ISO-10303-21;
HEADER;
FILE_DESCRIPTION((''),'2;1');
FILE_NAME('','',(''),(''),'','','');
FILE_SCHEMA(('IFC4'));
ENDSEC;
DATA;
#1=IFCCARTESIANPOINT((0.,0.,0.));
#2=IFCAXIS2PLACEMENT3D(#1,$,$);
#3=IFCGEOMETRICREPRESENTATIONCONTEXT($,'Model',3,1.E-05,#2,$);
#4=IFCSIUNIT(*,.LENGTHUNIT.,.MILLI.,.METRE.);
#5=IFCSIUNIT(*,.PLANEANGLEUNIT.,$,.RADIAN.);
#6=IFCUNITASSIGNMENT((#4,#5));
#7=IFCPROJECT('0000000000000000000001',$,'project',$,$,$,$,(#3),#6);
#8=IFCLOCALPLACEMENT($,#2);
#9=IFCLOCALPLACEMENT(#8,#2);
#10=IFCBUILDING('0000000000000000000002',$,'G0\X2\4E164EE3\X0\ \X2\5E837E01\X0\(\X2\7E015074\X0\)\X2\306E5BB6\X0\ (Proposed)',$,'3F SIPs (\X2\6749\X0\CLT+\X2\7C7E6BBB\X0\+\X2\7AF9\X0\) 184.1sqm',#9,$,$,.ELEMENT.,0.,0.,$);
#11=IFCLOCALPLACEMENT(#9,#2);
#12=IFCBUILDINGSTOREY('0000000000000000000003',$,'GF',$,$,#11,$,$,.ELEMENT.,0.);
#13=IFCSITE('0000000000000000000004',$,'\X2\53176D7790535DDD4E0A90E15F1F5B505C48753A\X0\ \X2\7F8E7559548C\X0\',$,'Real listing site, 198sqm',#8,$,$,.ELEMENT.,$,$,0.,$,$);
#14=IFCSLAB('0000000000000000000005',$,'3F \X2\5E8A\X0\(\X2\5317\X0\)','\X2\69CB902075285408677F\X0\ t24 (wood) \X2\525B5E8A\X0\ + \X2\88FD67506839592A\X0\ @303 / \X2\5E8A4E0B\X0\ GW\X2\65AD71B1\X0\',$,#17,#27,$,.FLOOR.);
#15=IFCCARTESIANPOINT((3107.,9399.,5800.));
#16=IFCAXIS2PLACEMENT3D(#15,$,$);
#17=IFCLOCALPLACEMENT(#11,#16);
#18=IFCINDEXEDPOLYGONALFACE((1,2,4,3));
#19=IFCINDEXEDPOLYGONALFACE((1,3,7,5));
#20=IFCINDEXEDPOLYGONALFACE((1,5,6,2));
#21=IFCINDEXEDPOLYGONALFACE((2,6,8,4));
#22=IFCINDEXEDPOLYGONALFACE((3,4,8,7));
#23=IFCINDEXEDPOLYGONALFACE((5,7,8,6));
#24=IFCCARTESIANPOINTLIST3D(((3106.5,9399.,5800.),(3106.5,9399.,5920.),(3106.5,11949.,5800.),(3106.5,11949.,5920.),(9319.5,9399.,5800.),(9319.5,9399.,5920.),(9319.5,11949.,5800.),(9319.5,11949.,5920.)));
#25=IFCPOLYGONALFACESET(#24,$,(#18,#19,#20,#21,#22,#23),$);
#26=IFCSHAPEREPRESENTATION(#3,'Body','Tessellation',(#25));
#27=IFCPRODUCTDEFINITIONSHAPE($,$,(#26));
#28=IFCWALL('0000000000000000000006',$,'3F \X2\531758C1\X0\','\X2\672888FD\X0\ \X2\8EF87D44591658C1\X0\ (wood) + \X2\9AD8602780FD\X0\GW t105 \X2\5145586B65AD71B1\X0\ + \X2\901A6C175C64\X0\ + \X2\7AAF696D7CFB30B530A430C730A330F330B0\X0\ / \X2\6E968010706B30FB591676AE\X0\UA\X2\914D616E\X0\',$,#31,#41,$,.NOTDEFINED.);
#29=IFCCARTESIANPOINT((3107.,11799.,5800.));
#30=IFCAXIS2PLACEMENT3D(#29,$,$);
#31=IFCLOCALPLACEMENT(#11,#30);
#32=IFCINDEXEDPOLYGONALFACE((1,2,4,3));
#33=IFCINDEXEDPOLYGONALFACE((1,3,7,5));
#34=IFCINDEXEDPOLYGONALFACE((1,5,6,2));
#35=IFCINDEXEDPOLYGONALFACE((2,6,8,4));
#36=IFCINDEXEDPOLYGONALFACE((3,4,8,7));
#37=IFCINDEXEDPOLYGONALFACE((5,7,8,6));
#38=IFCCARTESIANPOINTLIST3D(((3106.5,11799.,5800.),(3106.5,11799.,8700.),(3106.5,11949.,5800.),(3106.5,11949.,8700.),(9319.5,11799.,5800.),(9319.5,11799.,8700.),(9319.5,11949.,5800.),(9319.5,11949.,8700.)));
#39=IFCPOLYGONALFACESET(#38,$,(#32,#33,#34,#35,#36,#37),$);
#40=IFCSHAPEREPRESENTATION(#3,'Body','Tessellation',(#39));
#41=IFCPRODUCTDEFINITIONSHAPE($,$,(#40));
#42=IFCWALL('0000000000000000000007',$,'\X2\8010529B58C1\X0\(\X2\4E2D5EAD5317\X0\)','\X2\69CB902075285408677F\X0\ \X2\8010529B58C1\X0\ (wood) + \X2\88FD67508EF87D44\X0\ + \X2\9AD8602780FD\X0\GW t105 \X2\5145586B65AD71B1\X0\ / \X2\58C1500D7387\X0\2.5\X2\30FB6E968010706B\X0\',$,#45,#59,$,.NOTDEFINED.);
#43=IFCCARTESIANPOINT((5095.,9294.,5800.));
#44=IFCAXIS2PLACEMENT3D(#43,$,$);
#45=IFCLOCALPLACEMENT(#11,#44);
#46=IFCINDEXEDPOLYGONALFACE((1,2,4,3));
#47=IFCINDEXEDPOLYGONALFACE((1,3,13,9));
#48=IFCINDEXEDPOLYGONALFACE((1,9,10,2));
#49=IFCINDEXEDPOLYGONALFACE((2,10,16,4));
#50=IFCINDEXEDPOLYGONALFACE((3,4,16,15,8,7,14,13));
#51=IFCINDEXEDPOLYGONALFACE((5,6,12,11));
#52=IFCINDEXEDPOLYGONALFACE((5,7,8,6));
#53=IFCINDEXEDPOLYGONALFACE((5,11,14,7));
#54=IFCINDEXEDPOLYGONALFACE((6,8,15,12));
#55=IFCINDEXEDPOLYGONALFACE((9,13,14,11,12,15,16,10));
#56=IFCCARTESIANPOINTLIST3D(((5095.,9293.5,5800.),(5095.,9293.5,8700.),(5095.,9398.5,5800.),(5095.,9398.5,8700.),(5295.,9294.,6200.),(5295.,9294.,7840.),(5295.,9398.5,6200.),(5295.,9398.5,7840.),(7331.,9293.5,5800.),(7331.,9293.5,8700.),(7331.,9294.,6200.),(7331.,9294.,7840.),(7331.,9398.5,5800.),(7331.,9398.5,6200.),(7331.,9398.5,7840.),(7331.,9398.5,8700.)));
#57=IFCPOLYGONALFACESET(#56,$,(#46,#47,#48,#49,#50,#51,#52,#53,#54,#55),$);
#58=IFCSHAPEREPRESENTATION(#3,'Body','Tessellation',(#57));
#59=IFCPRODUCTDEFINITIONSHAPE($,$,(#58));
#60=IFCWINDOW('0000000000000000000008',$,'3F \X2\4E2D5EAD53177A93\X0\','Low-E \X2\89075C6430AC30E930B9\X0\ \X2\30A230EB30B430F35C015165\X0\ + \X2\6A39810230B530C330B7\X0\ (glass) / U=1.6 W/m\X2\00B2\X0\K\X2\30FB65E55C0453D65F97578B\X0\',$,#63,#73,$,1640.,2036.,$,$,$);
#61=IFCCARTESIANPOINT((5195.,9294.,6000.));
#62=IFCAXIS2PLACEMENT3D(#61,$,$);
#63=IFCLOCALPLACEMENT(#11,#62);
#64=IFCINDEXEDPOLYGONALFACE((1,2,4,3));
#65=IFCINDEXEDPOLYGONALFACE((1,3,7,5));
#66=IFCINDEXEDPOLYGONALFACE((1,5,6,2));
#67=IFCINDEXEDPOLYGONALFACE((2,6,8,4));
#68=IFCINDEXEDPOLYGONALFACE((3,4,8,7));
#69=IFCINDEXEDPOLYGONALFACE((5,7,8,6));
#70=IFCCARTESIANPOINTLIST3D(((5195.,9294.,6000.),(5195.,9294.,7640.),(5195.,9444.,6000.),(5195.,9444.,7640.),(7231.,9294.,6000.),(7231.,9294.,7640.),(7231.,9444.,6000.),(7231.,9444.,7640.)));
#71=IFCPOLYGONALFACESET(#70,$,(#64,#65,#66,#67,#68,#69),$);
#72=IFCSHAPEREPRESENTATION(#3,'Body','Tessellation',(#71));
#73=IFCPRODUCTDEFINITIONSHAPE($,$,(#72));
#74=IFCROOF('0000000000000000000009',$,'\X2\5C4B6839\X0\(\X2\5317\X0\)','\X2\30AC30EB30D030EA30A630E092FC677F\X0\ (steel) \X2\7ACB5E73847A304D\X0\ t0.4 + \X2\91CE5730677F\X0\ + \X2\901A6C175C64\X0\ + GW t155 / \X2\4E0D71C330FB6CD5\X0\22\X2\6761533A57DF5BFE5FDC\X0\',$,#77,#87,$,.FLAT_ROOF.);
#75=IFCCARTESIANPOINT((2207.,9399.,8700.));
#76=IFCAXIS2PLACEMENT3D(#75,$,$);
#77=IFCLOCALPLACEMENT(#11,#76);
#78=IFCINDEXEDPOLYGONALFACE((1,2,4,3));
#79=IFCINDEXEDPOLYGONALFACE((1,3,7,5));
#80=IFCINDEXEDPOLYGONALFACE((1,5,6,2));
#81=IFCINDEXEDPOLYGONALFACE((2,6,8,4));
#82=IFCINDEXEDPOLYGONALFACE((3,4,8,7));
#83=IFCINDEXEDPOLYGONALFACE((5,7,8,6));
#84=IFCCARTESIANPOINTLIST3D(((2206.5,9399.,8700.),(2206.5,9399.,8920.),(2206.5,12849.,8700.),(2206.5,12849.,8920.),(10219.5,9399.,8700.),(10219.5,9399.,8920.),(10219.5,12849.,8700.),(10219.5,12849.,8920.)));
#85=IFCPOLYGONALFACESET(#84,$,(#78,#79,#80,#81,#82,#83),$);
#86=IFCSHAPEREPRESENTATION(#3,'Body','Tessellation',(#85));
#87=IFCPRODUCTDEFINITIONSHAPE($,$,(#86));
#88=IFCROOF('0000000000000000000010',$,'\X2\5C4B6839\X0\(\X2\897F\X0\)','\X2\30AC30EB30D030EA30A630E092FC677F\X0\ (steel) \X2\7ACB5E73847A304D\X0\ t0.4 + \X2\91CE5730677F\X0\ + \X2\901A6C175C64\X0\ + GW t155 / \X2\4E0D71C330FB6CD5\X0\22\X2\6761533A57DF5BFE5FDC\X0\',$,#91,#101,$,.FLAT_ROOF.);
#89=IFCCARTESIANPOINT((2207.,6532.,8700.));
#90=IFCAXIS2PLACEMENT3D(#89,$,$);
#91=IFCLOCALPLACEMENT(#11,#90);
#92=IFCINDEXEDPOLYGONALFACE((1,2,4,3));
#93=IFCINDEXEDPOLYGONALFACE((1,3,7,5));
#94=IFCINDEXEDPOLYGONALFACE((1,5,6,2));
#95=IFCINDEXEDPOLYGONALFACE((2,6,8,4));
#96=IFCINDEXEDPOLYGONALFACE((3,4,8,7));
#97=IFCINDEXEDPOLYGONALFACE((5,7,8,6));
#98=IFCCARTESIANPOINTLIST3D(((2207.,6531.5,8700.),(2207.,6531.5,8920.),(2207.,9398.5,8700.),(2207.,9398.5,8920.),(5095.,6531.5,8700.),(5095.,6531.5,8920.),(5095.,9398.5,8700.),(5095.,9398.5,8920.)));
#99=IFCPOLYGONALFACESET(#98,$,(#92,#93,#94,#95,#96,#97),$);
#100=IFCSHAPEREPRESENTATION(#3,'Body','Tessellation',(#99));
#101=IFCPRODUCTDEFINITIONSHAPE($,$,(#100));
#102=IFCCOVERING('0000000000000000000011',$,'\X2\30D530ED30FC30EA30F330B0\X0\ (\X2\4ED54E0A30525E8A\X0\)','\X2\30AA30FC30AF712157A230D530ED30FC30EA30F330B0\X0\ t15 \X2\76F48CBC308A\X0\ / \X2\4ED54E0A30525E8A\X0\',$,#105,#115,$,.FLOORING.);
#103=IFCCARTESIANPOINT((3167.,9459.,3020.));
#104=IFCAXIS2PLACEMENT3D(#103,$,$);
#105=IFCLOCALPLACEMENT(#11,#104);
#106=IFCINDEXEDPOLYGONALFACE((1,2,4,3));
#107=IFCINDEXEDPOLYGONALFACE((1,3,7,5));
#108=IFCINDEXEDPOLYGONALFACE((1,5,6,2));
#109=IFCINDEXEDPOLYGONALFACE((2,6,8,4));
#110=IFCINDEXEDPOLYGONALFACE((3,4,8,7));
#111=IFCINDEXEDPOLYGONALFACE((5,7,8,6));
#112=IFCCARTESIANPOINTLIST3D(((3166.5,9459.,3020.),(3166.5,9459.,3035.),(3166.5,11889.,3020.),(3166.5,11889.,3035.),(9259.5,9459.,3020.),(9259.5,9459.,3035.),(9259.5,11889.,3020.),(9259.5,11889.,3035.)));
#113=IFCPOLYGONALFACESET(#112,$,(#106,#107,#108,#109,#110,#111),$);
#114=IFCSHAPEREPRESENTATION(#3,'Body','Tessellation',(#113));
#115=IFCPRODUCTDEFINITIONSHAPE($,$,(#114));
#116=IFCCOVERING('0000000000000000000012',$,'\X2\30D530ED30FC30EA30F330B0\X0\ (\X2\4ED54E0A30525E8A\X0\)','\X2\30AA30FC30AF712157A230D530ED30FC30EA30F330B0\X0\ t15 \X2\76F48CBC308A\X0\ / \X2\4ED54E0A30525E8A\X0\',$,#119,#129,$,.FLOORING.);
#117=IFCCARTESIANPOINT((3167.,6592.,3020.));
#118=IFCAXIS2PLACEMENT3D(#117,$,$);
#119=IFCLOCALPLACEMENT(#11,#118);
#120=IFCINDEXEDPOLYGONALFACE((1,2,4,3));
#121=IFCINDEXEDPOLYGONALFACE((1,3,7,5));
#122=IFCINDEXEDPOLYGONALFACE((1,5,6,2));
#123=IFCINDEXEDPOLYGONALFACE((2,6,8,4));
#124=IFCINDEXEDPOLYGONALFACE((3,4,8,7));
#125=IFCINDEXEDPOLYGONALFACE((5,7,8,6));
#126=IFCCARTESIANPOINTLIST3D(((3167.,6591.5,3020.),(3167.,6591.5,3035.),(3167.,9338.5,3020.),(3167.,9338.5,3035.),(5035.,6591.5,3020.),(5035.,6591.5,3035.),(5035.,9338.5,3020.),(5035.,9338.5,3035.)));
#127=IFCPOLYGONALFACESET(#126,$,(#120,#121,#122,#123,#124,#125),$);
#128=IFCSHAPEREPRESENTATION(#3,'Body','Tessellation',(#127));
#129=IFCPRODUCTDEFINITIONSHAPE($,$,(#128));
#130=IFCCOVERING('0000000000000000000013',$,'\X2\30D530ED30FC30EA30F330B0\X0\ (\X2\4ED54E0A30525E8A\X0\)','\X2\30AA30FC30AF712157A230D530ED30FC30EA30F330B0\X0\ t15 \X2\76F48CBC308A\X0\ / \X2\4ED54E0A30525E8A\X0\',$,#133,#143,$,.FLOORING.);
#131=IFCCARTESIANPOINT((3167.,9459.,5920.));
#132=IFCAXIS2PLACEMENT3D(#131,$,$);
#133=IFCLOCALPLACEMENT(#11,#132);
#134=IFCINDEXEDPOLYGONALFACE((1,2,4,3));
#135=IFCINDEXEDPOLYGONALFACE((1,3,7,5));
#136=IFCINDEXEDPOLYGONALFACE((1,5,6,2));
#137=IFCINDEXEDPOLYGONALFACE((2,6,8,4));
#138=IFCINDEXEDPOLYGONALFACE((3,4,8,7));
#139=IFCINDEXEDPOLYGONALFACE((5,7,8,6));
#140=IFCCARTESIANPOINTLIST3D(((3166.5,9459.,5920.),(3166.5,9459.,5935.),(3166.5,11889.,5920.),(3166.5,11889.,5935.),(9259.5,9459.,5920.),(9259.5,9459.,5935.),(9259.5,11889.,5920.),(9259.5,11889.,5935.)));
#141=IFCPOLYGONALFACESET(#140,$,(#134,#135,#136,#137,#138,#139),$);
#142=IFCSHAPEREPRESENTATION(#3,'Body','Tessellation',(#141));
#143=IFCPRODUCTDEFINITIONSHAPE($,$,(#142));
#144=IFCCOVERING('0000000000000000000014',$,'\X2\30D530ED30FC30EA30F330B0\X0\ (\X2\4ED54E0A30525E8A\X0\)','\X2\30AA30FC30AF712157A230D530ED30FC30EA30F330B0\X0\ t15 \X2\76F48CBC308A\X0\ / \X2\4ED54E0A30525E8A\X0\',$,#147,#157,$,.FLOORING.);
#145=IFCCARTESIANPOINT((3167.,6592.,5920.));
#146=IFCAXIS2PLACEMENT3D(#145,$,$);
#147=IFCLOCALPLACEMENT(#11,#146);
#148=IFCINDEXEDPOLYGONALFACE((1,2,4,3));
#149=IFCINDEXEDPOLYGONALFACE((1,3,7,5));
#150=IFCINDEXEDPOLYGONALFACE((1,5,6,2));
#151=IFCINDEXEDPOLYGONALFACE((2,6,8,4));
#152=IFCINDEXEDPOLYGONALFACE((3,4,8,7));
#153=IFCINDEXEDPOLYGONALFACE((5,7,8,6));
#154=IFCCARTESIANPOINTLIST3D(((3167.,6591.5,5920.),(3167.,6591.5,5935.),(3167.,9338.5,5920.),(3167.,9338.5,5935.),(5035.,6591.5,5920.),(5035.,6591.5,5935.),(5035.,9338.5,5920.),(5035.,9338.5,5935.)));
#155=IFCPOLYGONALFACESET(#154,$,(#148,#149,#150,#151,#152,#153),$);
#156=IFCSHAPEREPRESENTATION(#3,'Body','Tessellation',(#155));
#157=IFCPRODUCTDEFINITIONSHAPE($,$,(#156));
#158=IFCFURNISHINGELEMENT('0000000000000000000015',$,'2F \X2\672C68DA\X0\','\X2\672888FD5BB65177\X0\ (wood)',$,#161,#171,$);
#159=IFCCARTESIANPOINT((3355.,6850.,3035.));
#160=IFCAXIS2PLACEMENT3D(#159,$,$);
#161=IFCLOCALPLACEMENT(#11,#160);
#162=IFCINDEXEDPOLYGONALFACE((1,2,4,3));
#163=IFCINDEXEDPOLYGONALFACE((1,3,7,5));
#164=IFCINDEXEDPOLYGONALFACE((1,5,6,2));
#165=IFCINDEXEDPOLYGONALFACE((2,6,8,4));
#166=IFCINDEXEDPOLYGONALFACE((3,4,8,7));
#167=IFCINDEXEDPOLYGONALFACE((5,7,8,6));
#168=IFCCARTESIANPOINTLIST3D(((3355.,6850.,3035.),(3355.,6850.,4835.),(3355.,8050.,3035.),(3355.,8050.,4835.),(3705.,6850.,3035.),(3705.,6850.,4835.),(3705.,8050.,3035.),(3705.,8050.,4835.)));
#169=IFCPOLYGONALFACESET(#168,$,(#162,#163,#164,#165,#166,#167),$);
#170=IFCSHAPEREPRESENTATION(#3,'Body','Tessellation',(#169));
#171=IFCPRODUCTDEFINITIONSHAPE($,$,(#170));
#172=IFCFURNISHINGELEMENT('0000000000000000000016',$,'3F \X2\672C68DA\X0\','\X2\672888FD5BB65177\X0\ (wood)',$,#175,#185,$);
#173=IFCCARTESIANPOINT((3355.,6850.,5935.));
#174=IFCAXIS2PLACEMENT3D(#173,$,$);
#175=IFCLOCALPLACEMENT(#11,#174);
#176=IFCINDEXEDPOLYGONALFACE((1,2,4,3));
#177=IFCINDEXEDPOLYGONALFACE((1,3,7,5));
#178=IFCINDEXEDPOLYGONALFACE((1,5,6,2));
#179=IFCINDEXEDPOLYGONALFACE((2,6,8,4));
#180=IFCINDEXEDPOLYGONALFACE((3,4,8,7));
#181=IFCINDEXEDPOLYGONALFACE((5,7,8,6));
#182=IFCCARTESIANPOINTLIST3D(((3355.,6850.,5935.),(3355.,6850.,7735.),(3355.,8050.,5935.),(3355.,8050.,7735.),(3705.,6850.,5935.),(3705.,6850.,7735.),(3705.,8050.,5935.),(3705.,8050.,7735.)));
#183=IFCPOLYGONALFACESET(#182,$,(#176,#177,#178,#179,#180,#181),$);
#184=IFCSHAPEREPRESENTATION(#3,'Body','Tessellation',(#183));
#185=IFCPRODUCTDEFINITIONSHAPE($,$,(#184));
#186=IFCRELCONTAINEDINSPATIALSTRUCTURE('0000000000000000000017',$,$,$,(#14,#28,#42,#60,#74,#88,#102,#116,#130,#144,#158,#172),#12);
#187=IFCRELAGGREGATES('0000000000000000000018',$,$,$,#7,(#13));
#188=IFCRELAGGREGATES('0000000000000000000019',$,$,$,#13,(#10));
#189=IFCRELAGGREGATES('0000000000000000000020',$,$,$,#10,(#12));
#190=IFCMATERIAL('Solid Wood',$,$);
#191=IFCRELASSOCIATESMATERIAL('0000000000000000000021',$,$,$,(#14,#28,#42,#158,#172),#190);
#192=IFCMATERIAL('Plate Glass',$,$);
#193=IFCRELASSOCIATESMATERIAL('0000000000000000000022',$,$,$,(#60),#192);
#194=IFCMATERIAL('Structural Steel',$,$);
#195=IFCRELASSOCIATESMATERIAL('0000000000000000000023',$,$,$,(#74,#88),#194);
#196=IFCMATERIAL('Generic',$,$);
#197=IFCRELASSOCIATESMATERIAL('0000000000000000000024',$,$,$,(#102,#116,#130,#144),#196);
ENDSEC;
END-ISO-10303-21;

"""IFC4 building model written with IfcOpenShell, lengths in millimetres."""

from ifc_helpers import new_model, si_unit, frame, frame_2d, origin, place, context, project, spatial, rectangle, extrude, material, element, fill, save


model = new_model("IFC4")

# Units and contexts
model_context = context("Model", 3, precision=1e-05, world=origin())
ifc_project = project(units=[si_unit("LENGTHUNIT", "METRE", prefix="MILLI"), si_unit("PLANEANGLEUNIT", "RADIAN")], contexts=[model_context])

# Site, building, storey
site_placement = place(None, origin())
site = spatial("IfcSite", under=ifc_project, at=site_placement, Name="北海道川上郡弟子屈町 美留和", ObjectType="Real listing site, 198sqm", CompositionType="ELEMENT", RefElevation=0.0)
building_placement = place(site_placement, origin())
building = spatial("IfcBuilding", under=site, at=building_placement, Name="G0世代 広縁(縁側)の家 (Proposed)", ObjectType="3F SIPs (杉CLT+籾殻+竹) 184.1sqm", CompositionType="ELEMENT", ElevationOfRefHeight=0.0, ElevationOfTerrain=0.0)
storey_placement = place(building_placement, origin())
storey = spatial("IfcBuildingStorey", under=building, at=storey_placement, Name="GF", CompositionType="ELEMENT", Elevation=0.0)

# Slab
ifc_material_1 = material(Name="Solid Wood")
slab_placement = place(storey_placement, frame((3107.0, 9399.0, 5800.0)))
element("IfcSlab", 1, at=slab_placement, inside=storey, material=ifc_material_1, Name="3F 床(北)", Description="構造用合板 t24 (wood) 剛床 + 製材根太 @303 / 床下 GW断熱", PredefinedType="FLOOR", context=model_context, shape_type="SweptSolid", body=[
    extrude(rectangle(XDim=6213.0, YDim=2550.0, at=frame_2d((3106.0, 1275.0))), frame((3107.0, 9399.0, 5800.0)), (0.0, 0.0, 1.0), 120.0),
])

# Wall
wall_1_placement = place(storey_placement, frame((3107.0, 11799.0, 5800.0)))
element("IfcWall", 2, at=wall_1_placement, inside=storey, material=ifc_material_1, Name="3F 北壁", Description="木製 軸組外壁 (wood) + 高性能GW t105 充填断熱 + 通気層 + 窯業系サイディング / 準耐火・外皮UA配慮", PredefinedType="NOTDEFINED", context=model_context, shape_type="SweptSolid", body=[
    extrude(rectangle(XDim=6213.0, YDim=150.0, at=frame_2d((3106.0, 75.0))), frame((3107.0, 11799.0, 5800.0)), (0.0, 0.0, 1.0), 2900.0),
])

# Wall, opening, window
wall_2_placement = place(storey_placement, frame((5095.0, 9294.0, 5800.0)))
wall_2 = element("IfcWall", 3, at=wall_2_placement, inside=storey, material=ifc_material_1, Name="耐力壁(中庭北)", Description="構造用合板 耐力壁 (wood) + 製材軸組 + 高性能GW t105 充填断熱 / 壁倍率2.5・準耐火", PredefinedType="NOTDEFINED", context=model_context, shape_type="SweptSolid", body=[
    extrude(rectangle(XDim=2236.0, YDim=105.0, at=frame_2d((1118.0, 52.0))), frame((5095.0, 9294.0, 5800.0)), (0.0, 0.0, 1.0), 2900.0),
])
opening_placement = place(storey_placement, frame((5195.0, 9294.0, 6000.0)))
opening = element("IfcOpeningElement", 4, at=opening_placement, cuts=wall_2, PredefinedType="NOTDEFINED", context=model_context, shape_type="SweptSolid", body=[
    extrude(rectangle(XDim=2036.0, YDim=150.0, at=frame_2d((1018.0, 75.0))), frame((5195.0, 9294.0, 6000.0)), (0.0, 0.0, 1.0), 1640.0),
])
ifc_material_2 = material(Name="Plate Glass")
window_1_placement = place(storey_placement, frame((5195.0, 9294.0, 6000.0)))
window_1 = element("IfcWindow", 5, at=window_1_placement, inside=storey, material=ifc_material_2, Name="3F 中庭北窓", Description="Low-E 複層ガラス アルゴン封入 + 樹脂サッシ (glass) / U=1.6 W/m²K・日射取得型", OverallHeight=1640.0, OverallWidth=2036.0, context=model_context, shape_type="SweptSolid", body=[
    extrude(rectangle(XDim=2036.0, YDim=150.0, at=frame_2d((1018.0, 75.0))), frame((5195.0, 9294.0, 6000.0)), (0.0, 0.0, 1.0), 1640.0),
])
fill(opening, window_1)

# Shared definitions
ifc_material_3 = material(Name="Generic")

# Roofs
ifc_material_4 = material(Name="Structural Steel")
roof_1_placement = place(storey_placement, frame((2207.0, 9399.0, 8700.0)))
element("IfcRoof", 6, at=roof_1_placement, inside=storey, material=ifc_material_4, Name="屋根(北)", Description="ガルバリウム鋼板 (steel) 立平葺き t0.4 + 野地板 + 通気層 + GW t155 / 不燃・法22条区域対応", PredefinedType="FLAT_ROOF", context=model_context, shape_type="SweptSolid", body=[
    extrude(rectangle(XDim=8013.0, YDim=3450.0, at=frame_2d((4006.0, 1725.0))), frame((2207.0, 9399.0, 8700.0)), (0.0, 0.0, 1.0), 220.0),
])
roof_2_placement = place(storey_placement, frame((2207.0, 6532.0, 8700.0)))
element("IfcRoof", 7, at=roof_2_placement, inside=storey, material=ifc_material_4, Name="屋根(西)", Description="ガルバリウム鋼板 (steel) 立平葺き t0.4 + 野地板 + 通気層 + GW t155 / 不燃・法22条区域対応", PredefinedType="FLAT_ROOF", context=model_context, shape_type="SweptSolid", body=[
    extrude(rectangle(XDim=2888.0, YDim=2867.0, at=frame_2d((1444.0, 1433.0))), frame((2207.0, 6532.0, 8700.0)), (0.0, 0.0, 1.0), 220.0),
])

# Coverings
covering_1_placement = place(storey_placement, frame((3167.0, 9459.0, 3020.0)))
element("IfcCovering", 8, at=covering_1_placement, inside=storey, material=ifc_material_3, Name="フローリング (仕上げ床)", Description="オーク無垢フローリング t15 直貼り / 仕上げ床", PredefinedType="FLOORING", context=model_context, shape_type="SweptSolid", body=[
    extrude(rectangle(XDim=6093.0, YDim=2430.0, at=frame_2d((3046.0, 1215.0))), frame((3167.0, 9459.0, 3020.0)), (0.0, 0.0, 1.0), 15.0),
])
covering_2_placement = place(storey_placement, frame((3167.0, 6592.0, 3020.0)))
element("IfcCovering", 9, at=covering_2_placement, inside=storey, material=ifc_material_3, Name="フローリング (仕上げ床)", Description="オーク無垢フローリング t15 直貼り / 仕上げ床", PredefinedType="FLOORING", context=model_context, shape_type="SweptSolid", body=[
    extrude(rectangle(XDim=1868.0, YDim=2747.0, at=frame_2d((934.0, 1373.0))), frame((3167.0, 6592.0, 3020.0)), (0.0, 0.0, 1.0), 15.0),
])
covering_3_placement = place(storey_placement, frame((3167.0, 9459.0, 5920.0)))
element("IfcCovering", 10, at=covering_3_placement, inside=storey, material=ifc_material_3, Name="フローリング (仕上げ床)", Description="オーク無垢フローリング t15 直貼り / 仕上げ床", PredefinedType="FLOORING", context=model_context, shape_type="SweptSolid", body=[
    extrude(rectangle(XDim=6093.0, YDim=2430.0, at=frame_2d((3046.0, 1215.0))), frame((3167.0, 9459.0, 5920.0)), (0.0, 0.0, 1.0), 15.0),
])
covering_4_placement = place(storey_placement, frame((3167.0, 6592.0, 5920.0)))
element("IfcCovering", 11, at=covering_4_placement, inside=storey, material=ifc_material_3, Name="フローリング (仕上げ床)", Description="オーク無垢フローリング t15 直貼り / 仕上げ床", PredefinedType="FLOORING", context=model_context, shape_type="SweptSolid", body=[
    extrude(rectangle(XDim=1868.0, YDim=2747.0, at=frame_2d((934.0, 1373.0))), frame((3167.0, 6592.0, 5920.0)), (0.0, 0.0, 1.0), 15.0),
])

# Furnishing elements
furnishing_1_placement = place(storey_placement, frame((3355.0, 6850.0, 3035.0)))
element("IfcFurnishingElement", 12, at=furnishing_1_placement, inside=storey, material=ifc_material_1, Name="2F 本棚", Description="木製家具 (wood)", context=model_context, shape_type="SweptSolid", body=[
    extrude(rectangle(XDim=350.0, YDim=1200.0, at=frame_2d((175.0, 600.0))), frame((3355.0, 6850.0, 3035.0)), (0.0, 0.0, 1.0), 1800.0),
])
furnishing_2_placement = place(storey_placement, frame((3355.0, 6850.0, 5935.0)))
element("IfcFurnishingElement", 13, at=furnishing_2_placement, inside=storey, material=ifc_material_1, Name="3F 本棚", Description="木製家具 (wood)", context=model_context, shape_type="SweptSolid", body=[
    extrude(rectangle(XDim=350.0, YDim=1200.0, at=frame_2d((175.0, 600.0))), frame((3355.0, 6850.0, 5935.0)), (0.0, 0.0, 1.0), 1800.0),
])

save(model, "model.ifc")
